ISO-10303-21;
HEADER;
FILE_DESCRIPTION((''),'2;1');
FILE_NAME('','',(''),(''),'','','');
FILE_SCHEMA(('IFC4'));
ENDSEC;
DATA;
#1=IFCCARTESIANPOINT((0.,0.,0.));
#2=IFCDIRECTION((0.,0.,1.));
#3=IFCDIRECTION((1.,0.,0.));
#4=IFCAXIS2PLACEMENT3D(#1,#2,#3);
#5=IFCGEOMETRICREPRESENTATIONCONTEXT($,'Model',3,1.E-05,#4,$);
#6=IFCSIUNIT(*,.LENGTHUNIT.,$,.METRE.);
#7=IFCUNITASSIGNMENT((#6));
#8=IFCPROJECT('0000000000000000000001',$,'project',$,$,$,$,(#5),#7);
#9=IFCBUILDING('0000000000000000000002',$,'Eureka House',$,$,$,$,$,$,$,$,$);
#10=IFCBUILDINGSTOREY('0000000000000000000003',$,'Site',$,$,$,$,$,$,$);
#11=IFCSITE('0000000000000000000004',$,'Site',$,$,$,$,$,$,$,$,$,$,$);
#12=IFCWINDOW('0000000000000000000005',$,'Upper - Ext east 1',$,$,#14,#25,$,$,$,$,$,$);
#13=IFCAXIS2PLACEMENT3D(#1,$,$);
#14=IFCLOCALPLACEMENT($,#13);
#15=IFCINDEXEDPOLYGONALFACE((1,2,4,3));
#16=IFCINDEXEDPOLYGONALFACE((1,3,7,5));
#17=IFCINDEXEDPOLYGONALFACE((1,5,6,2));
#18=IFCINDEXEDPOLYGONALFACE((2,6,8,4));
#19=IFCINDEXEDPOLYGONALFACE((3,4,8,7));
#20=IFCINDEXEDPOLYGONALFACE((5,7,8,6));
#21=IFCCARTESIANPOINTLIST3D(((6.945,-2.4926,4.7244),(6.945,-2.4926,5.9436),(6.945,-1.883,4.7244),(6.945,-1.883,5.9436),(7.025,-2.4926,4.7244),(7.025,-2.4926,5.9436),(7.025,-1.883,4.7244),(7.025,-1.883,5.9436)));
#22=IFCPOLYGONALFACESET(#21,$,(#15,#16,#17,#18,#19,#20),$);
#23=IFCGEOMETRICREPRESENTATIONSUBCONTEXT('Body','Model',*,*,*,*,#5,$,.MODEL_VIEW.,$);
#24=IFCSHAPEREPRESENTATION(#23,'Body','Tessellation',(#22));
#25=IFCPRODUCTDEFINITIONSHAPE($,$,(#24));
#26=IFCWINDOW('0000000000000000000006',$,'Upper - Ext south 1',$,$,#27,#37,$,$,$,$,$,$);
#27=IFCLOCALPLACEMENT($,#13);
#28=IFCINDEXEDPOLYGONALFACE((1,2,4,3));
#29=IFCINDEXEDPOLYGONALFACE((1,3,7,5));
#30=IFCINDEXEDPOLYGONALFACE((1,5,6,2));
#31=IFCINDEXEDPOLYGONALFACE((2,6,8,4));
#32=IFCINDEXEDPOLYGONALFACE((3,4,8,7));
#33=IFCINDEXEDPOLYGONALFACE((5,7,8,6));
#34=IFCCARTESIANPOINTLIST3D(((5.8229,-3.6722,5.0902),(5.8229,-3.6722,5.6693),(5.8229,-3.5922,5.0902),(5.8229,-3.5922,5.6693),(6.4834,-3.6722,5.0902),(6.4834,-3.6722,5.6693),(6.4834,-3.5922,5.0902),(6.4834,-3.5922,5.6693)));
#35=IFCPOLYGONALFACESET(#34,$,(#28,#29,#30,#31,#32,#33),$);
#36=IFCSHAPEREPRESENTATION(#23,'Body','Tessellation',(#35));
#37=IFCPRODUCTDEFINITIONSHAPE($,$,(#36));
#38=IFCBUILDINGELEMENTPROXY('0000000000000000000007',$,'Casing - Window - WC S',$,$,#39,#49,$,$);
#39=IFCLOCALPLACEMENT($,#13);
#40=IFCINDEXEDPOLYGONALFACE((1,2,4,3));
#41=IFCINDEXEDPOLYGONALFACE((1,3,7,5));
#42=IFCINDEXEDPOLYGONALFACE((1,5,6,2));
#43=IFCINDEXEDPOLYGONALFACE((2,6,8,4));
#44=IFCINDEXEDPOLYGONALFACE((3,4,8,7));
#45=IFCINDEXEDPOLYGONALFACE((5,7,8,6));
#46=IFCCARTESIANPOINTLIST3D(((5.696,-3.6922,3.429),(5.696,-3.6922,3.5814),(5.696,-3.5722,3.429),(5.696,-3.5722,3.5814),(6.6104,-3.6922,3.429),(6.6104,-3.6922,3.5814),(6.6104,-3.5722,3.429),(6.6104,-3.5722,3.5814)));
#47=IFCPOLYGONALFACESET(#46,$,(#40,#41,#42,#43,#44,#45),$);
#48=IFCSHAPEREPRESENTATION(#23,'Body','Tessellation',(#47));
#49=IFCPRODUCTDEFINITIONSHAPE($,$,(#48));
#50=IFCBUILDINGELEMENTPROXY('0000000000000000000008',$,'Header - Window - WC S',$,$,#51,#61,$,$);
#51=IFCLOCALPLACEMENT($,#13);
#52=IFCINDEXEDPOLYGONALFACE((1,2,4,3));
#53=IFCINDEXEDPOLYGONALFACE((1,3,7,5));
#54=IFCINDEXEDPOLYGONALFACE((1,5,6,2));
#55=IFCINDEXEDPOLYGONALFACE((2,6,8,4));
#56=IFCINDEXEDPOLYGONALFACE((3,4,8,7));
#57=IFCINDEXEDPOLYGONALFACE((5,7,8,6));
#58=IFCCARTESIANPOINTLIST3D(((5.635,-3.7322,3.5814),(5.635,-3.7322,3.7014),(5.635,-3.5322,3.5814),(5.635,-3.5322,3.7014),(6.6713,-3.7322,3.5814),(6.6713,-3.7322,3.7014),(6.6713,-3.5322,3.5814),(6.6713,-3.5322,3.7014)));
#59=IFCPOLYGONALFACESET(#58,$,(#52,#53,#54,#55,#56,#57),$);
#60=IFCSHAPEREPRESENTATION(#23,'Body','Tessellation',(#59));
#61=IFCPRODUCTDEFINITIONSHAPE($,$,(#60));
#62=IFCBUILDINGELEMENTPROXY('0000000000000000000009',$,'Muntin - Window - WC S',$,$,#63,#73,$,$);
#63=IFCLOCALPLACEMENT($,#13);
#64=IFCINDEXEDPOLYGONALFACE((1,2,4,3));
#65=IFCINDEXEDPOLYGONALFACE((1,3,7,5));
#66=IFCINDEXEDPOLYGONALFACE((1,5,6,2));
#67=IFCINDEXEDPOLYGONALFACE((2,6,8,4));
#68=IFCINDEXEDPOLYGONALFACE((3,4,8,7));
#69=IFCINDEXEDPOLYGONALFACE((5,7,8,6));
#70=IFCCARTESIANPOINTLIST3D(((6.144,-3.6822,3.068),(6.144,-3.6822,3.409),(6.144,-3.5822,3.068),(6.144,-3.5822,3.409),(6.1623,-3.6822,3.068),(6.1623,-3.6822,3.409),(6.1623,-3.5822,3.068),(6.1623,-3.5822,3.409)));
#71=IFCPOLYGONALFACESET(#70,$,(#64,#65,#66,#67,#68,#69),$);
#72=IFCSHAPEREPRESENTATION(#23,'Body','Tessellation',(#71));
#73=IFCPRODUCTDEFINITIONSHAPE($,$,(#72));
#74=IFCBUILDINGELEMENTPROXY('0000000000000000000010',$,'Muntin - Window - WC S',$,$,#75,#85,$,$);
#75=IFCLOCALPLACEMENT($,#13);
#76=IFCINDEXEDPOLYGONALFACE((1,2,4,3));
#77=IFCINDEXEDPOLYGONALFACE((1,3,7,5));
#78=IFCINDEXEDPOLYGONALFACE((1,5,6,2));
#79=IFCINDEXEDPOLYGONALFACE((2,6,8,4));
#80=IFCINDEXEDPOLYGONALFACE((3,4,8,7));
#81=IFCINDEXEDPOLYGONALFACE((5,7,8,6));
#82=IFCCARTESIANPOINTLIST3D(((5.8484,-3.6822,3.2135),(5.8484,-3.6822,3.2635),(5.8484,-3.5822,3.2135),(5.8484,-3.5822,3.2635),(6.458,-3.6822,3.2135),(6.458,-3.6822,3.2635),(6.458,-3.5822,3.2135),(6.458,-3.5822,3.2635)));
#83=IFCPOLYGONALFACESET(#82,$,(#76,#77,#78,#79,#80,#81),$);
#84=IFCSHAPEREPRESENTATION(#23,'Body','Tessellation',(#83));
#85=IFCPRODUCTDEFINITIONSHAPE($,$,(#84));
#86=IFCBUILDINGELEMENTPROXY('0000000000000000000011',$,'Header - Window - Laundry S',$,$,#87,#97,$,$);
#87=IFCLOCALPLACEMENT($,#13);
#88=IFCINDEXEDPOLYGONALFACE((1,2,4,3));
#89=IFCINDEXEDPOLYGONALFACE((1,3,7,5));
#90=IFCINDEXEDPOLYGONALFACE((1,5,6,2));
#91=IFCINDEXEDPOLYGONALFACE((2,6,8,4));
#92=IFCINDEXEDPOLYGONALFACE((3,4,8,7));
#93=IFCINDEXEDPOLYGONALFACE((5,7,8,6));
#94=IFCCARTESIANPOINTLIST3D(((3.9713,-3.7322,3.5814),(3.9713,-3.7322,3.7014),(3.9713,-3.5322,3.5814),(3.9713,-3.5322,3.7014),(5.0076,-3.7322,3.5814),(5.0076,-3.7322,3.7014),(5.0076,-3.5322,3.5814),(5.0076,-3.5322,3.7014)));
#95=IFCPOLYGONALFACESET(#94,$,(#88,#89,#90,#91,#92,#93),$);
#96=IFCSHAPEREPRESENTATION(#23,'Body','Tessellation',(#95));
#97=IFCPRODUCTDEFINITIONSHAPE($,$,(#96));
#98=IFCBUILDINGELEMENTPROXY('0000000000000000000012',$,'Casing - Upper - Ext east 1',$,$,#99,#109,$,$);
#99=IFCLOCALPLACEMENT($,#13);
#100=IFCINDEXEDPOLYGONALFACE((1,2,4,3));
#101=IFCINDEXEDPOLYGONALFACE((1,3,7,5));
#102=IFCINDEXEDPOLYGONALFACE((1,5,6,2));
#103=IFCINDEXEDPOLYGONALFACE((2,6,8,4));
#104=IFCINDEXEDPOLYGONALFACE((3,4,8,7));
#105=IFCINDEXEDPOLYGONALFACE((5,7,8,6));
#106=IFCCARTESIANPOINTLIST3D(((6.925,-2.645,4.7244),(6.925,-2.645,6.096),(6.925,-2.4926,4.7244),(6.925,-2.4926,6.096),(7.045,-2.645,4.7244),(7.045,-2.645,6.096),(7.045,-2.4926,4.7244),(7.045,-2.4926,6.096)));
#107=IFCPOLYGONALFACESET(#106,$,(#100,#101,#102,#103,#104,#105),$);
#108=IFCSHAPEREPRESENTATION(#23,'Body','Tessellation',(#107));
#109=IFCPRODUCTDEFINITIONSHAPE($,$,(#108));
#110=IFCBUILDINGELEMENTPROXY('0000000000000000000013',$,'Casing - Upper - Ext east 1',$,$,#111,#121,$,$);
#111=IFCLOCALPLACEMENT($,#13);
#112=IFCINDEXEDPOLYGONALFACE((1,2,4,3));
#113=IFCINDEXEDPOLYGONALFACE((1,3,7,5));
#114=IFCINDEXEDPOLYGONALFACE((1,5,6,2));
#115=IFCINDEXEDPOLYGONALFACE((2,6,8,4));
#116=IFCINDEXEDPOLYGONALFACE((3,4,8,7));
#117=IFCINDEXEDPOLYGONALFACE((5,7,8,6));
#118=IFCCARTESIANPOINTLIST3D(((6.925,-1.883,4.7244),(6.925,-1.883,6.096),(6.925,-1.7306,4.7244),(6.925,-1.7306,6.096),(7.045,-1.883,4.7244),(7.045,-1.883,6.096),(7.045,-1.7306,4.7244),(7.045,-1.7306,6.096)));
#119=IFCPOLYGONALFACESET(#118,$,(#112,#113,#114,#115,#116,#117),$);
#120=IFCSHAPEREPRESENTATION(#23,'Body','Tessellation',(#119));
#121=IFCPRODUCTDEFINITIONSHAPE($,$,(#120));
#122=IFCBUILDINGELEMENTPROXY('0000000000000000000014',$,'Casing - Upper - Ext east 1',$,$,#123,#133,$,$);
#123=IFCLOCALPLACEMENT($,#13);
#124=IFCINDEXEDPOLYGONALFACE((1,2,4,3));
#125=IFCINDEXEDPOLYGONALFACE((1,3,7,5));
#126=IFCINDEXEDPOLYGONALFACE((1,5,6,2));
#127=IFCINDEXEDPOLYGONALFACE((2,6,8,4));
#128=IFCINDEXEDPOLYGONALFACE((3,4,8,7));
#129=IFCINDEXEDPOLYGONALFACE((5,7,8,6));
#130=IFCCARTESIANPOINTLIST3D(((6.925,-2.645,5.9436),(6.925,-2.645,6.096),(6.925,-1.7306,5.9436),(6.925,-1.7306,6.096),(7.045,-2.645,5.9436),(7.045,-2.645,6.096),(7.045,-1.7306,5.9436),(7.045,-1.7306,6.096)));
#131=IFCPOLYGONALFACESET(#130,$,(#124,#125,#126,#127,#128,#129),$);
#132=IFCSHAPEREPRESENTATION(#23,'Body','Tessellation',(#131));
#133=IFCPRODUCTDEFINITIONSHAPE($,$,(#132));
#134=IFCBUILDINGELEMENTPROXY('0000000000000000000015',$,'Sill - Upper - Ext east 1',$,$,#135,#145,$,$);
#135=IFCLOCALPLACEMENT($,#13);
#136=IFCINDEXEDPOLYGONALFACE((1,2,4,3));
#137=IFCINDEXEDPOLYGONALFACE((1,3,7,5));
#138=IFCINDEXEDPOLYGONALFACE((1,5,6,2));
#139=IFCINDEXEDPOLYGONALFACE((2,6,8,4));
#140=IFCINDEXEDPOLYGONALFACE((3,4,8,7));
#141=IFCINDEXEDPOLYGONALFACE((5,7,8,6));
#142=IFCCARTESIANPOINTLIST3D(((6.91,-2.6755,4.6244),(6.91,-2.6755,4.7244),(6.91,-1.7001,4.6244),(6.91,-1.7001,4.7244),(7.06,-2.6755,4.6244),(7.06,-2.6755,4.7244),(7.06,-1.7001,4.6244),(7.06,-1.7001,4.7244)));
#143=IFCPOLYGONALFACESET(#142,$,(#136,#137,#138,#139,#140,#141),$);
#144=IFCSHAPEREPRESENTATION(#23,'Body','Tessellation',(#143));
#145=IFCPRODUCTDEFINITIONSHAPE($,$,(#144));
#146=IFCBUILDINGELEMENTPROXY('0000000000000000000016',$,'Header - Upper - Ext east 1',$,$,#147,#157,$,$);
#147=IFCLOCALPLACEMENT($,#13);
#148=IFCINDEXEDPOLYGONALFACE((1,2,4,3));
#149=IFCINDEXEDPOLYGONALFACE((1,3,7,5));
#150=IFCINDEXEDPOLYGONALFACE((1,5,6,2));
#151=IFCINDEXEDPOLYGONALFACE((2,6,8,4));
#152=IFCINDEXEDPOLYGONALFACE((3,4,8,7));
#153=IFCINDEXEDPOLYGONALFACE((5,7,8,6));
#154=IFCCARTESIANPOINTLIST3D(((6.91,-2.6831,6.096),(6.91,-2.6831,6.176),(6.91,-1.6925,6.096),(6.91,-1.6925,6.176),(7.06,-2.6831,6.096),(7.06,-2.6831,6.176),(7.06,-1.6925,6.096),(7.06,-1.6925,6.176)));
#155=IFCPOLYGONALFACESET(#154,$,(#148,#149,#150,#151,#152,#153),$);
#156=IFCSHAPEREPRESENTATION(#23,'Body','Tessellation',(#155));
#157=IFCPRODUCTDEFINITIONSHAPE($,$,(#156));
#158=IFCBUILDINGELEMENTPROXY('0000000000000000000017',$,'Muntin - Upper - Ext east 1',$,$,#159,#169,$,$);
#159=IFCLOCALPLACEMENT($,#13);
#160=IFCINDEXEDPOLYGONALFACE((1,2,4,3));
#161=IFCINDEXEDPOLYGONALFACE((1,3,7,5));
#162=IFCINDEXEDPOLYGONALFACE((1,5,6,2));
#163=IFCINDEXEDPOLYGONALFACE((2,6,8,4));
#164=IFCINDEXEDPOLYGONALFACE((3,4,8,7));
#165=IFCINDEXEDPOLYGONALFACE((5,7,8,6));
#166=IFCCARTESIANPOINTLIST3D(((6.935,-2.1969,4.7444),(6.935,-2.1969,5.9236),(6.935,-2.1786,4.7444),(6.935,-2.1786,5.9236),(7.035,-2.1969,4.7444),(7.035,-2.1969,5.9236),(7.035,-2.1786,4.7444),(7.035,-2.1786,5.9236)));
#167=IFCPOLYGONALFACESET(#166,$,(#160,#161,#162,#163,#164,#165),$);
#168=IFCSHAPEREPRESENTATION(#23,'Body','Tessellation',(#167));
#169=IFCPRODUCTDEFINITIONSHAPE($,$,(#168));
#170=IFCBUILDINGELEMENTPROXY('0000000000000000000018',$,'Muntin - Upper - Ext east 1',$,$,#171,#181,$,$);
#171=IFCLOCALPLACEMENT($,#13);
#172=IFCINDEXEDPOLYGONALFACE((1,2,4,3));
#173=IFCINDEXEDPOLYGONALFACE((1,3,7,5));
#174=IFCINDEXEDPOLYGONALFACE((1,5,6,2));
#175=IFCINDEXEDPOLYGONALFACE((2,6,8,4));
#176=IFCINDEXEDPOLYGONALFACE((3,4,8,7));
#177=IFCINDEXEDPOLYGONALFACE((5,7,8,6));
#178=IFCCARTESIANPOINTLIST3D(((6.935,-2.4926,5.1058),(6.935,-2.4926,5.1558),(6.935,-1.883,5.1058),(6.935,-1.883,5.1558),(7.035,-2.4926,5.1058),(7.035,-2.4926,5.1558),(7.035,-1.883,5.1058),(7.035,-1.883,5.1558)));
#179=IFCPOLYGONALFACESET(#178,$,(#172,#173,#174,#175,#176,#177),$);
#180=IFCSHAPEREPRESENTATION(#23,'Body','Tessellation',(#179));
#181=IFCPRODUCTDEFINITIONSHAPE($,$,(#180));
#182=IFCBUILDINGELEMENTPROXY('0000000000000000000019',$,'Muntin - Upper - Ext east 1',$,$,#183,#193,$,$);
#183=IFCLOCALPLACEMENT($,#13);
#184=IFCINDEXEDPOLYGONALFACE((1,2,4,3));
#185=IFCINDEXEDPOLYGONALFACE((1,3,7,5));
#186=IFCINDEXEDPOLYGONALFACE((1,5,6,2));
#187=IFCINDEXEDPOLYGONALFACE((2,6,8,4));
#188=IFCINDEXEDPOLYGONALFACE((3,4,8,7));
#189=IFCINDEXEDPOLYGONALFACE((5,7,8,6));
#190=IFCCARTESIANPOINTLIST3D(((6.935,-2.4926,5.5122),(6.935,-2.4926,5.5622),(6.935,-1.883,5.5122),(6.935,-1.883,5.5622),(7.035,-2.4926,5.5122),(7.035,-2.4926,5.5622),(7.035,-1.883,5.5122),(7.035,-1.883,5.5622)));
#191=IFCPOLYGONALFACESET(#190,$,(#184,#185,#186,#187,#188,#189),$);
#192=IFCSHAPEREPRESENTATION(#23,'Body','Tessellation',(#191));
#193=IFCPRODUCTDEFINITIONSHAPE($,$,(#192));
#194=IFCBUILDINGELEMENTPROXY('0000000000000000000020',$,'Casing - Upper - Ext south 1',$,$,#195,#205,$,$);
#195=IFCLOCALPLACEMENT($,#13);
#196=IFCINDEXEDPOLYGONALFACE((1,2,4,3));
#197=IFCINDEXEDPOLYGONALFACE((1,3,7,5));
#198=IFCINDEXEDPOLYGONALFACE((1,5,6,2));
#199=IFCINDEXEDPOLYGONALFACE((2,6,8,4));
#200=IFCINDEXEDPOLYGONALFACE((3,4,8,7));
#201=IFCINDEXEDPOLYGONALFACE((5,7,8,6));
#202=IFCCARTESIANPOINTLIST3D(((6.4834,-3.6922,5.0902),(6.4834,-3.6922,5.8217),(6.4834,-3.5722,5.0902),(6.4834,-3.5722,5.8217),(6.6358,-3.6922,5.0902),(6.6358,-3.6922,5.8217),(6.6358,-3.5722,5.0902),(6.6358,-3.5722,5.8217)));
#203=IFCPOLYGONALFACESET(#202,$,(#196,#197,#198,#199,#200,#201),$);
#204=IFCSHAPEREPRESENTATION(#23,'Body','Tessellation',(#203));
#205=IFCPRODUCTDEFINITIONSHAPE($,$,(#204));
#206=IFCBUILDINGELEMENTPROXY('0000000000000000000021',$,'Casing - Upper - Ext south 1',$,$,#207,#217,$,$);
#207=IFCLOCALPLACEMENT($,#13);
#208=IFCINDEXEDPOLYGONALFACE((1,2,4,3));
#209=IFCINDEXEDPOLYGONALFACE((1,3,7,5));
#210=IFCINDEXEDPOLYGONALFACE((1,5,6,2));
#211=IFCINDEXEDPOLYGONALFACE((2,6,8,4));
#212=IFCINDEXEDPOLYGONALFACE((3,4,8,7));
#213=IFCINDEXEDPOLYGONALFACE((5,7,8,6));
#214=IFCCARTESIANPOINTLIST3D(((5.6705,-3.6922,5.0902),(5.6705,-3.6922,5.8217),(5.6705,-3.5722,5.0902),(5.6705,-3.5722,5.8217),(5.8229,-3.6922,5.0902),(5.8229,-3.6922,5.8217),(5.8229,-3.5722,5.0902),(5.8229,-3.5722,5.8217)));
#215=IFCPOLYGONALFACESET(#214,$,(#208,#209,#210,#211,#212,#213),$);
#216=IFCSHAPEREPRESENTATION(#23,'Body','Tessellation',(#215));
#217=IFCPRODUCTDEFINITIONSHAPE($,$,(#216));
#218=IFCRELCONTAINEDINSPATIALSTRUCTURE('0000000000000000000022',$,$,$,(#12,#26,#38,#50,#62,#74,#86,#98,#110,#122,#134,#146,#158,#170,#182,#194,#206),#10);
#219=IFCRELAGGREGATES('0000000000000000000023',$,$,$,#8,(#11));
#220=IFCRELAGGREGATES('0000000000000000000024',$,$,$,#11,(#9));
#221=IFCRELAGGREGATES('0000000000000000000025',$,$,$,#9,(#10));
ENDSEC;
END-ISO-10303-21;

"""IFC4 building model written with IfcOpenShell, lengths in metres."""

from ifc_helpers import new_model, si_unit, frame, origin, origin_with_axes, origin_2d, place, context, subcontext, project, spatial, rectangle, extrude, element, save


model = new_model("IFC4")

# Units and contexts
model_context = context("Model", 3, precision=1e-05, world=origin_with_axes())
body_context = subcontext(model_context, "Body", "Model", "MODEL_VIEW")
ifc_project = project(units=[si_unit("LENGTHUNIT", "METRE")], contexts=[model_context])

# Site, building, storey
site = spatial("IfcSite", under=ifc_project, Name="Site")
building = spatial("IfcBuilding", under=site, Name="Eureka House")
storey = spatial("IfcBuildingStorey", under=building, Name="Site")

# Windows
window_1_placement = place(None, frame((6.985, -2.1878, 4.7244), z_axis=(0.0, 0.0, 1.0), x_axis=(1.0, 0.0, 0.0)))
element("IfcWindow", 1, at=window_1_placement, inside=storey, Name="Upper - Ext east 1", context=body_context, shape_type="SweptSolid", body=[
    extrude(rectangle(XDim=0.08, YDim=0.6096, at=origin_2d()), origin(), (0.0, 0.0, 1.0), 1.2192),
])
window_2_placement = place(None, frame((6.1532, -3.6322, 5.0902), z_axis=(0.0, 0.0, 1.0), x_axis=(1.0, 0.0, 0.0)))
element("IfcWindow", 2, at=window_2_placement, inside=storey, Name="Upper - Ext south 1", context=body_context, shape_type="SweptSolid", body=[
    extrude(rectangle(XDim=0.6605, YDim=0.08, at=origin_2d()), origin(), (0.0, 0.0, 1.0), 0.5791),
])

# Building element proxies
proxy_1_placement = place(None, frame((6.1532, -3.6322, 3.429), z_axis=(0.0, 0.0, 1.0), x_axis=(1.0, 0.0, 0.0)))
element("IfcBuildingElementProxy", 3, at=proxy_1_placement, inside=storey, Name="Casing - Window - WC S", context=body_context, shape_type="SweptSolid", body=[
    extrude(rectangle(XDim=0.9144, YDim=0.12, at=origin_2d()), origin(), (0.0, 0.0, 1.0), 0.1524),
])
proxy_2_placement = place(None, frame((6.1532, -3.6322, 3.5814), z_axis=(0.0, 0.0, 1.0), x_axis=(1.0, 0.0, 0.0)))
element("IfcBuildingElementProxy", 4, at=proxy_2_placement, inside=storey, Name="Header - Window - WC S", context=body_context, shape_type="SweptSolid", body=[
    extrude(rectangle(XDim=1.0363, YDim=0.2, at=origin_2d()), origin(), (0.0, 0.0, 1.0), 0.12),
])
proxy_3_placement = place(None, frame((6.1532, -3.6322, 3.068), z_axis=(0.0, 0.0, 1.0), x_axis=(1.0, 0.0, 0.0)))
element("IfcBuildingElementProxy", 5, at=proxy_3_placement, inside=storey, Name="Muntin - Window - WC S", context=body_context, shape_type="SweptSolid", body=[
    extrude(rectangle(XDim=0.0183, YDim=0.1, at=origin_2d()), origin(), (0.0, 0.0, 1.0), 0.341),
])
proxy_4_placement = place(None, frame((6.1532, -3.6322, 3.2135), z_axis=(0.0, 0.0, 1.0), x_axis=(1.0, 0.0, 0.0)))
element("IfcBuildingElementProxy", 6, at=proxy_4_placement, inside=storey, Name="Muntin - Window - WC S", context=body_context, shape_type="SweptSolid", body=[
    extrude(rectangle(XDim=0.6096, YDim=0.1, at=origin_2d()), origin(), (0.0, 0.0, 1.0), 0.05),
])
proxy_5_placement = place(None, frame((4.4895, -3.6322, 3.5814), z_axis=(0.0, 0.0, 1.0), x_axis=(1.0, 0.0, 0.0)))
element("IfcBuildingElementProxy", 7, at=proxy_5_placement, inside=storey, Name="Header - Window - Laundry S", context=body_context, shape_type="SweptSolid", body=[
    extrude(rectangle(XDim=1.0363, YDim=0.2, at=origin_2d()), origin(), (0.0, 0.0, 1.0), 0.12),
])
for number, where, z_axis, x_axis, name in (
    (8, (6.985, -2.5688, 4.7244), (0.0, 0.0, 1.0), (1.0, 0.0, 0.0), "Casing - Upper - Ext east 1"),
    (9, (6.985, -1.8068, 4.7244), (0.0, 0.0, 1.0), (1.0, 0.0, 0.0), "Casing - Upper - Ext east 1"),
):
    element("IfcBuildingElementProxy", number, at=place(None, frame(where, z_axis=z_axis, x_axis=x_axis)), inside=storey, Name=name, context=body_context, shape_type="SweptSolid", body=[
        extrude(rectangle(XDim=0.12, YDim=0.1524, at=origin_2d()), origin(), (0.0, 0.0, 1.0), 1.3716),
    ])
proxy_6_placement = place(None, frame((6.985, -2.1878, 5.9436), z_axis=(0.0, 0.0, 1.0), x_axis=(1.0, 0.0, 0.0)))
element("IfcBuildingElementProxy", 10, at=proxy_6_placement, inside=storey, Name="Casing - Upper - Ext east 1", context=body_context, shape_type="SweptSolid", body=[
    extrude(rectangle(XDim=0.12, YDim=0.9144, at=origin_2d()), origin(), (0.0, 0.0, 1.0), 0.1524),
])
proxy_7_placement = place(None, frame((6.985, -2.1878, 4.6244), z_axis=(0.0, 0.0, 1.0), x_axis=(1.0, 0.0, 0.0)))
element("IfcBuildingElementProxy", 11, at=proxy_7_placement, inside=storey, Name="Sill - Upper - Ext east 1", context=body_context, shape_type="SweptSolid", body=[
    extrude(rectangle(XDim=0.15, YDim=0.9754, at=origin_2d()), origin(), (0.0, 0.0, 1.0), 0.1),
])
proxy_8_placement = place(None, frame((6.985, -2.1878, 6.096), z_axis=(0.0, 0.0, 1.0), x_axis=(1.0, 0.0, 0.0)))
element("IfcBuildingElementProxy", 12, at=proxy_8_placement, inside=storey, Name="Header - Upper - Ext east 1", context=body_context, shape_type="SweptSolid", body=[
    extrude(rectangle(XDim=0.15, YDim=0.9906, at=origin_2d()), origin(), (0.0, 0.0, 1.0), 0.08),
])
proxy_9_placement = place(None, frame((6.985, -2.1878, 4.7444), z_axis=(0.0, 0.0, 1.0), x_axis=(1.0, 0.0, 0.0)))
element("IfcBuildingElementProxy", 13, at=proxy_9_placement, inside=storey, Name="Muntin - Upper - Ext east 1", context=body_context, shape_type="SweptSolid", body=[
    extrude(rectangle(XDim=0.1, YDim=0.0183, at=origin_2d()), origin(), (0.0, 0.0, 1.0), 1.1792),
])
for number, where, z_axis, x_axis, name in (
    (14, (6.985, -2.1878, 5.1058), (0.0, 0.0, 1.0), (1.0, 0.0, 0.0), "Muntin - Upper - Ext east 1"),
    (15, (6.985, -2.1878, 5.5122), (0.0, 0.0, 1.0), (1.0, 0.0, 0.0), "Muntin - Upper - Ext east 1"),
):
    element("IfcBuildingElementProxy", number, at=place(None, frame(where, z_axis=z_axis, x_axis=x_axis)), inside=storey, Name=name, context=body_context, shape_type="SweptSolid", body=[
        extrude(rectangle(XDim=0.1, YDim=0.6096, at=origin_2d()), origin(), (0.0, 0.0, 1.0), 0.05),
    ])
for number, where, z_axis, x_axis, name in (
    (16, (6.5596, -3.6322, 5.0902), (0.0, 0.0, 1.0), (1.0, 0.0, 0.0), "Casing - Upper - Ext south 1"),
    (17, (5.7467, -3.6322, 5.0902), (0.0, 0.0, 1.0), (1.0, 0.0, 0.0), "Casing - Upper - Ext south 1"),
):
    element("IfcBuildingElementProxy", number, at=place(None, frame(where, z_axis=z_axis, x_axis=x_axis)), inside=storey, Name=name, context=body_context, shape_type="SweptSolid", body=[
        extrude(rectangle(XDim=0.1524, YDim=0.12, at=origin_2d()), origin(), (0.0, 0.0, 1.0), 0.7315),
    ])

save(model, "model.ifc")
